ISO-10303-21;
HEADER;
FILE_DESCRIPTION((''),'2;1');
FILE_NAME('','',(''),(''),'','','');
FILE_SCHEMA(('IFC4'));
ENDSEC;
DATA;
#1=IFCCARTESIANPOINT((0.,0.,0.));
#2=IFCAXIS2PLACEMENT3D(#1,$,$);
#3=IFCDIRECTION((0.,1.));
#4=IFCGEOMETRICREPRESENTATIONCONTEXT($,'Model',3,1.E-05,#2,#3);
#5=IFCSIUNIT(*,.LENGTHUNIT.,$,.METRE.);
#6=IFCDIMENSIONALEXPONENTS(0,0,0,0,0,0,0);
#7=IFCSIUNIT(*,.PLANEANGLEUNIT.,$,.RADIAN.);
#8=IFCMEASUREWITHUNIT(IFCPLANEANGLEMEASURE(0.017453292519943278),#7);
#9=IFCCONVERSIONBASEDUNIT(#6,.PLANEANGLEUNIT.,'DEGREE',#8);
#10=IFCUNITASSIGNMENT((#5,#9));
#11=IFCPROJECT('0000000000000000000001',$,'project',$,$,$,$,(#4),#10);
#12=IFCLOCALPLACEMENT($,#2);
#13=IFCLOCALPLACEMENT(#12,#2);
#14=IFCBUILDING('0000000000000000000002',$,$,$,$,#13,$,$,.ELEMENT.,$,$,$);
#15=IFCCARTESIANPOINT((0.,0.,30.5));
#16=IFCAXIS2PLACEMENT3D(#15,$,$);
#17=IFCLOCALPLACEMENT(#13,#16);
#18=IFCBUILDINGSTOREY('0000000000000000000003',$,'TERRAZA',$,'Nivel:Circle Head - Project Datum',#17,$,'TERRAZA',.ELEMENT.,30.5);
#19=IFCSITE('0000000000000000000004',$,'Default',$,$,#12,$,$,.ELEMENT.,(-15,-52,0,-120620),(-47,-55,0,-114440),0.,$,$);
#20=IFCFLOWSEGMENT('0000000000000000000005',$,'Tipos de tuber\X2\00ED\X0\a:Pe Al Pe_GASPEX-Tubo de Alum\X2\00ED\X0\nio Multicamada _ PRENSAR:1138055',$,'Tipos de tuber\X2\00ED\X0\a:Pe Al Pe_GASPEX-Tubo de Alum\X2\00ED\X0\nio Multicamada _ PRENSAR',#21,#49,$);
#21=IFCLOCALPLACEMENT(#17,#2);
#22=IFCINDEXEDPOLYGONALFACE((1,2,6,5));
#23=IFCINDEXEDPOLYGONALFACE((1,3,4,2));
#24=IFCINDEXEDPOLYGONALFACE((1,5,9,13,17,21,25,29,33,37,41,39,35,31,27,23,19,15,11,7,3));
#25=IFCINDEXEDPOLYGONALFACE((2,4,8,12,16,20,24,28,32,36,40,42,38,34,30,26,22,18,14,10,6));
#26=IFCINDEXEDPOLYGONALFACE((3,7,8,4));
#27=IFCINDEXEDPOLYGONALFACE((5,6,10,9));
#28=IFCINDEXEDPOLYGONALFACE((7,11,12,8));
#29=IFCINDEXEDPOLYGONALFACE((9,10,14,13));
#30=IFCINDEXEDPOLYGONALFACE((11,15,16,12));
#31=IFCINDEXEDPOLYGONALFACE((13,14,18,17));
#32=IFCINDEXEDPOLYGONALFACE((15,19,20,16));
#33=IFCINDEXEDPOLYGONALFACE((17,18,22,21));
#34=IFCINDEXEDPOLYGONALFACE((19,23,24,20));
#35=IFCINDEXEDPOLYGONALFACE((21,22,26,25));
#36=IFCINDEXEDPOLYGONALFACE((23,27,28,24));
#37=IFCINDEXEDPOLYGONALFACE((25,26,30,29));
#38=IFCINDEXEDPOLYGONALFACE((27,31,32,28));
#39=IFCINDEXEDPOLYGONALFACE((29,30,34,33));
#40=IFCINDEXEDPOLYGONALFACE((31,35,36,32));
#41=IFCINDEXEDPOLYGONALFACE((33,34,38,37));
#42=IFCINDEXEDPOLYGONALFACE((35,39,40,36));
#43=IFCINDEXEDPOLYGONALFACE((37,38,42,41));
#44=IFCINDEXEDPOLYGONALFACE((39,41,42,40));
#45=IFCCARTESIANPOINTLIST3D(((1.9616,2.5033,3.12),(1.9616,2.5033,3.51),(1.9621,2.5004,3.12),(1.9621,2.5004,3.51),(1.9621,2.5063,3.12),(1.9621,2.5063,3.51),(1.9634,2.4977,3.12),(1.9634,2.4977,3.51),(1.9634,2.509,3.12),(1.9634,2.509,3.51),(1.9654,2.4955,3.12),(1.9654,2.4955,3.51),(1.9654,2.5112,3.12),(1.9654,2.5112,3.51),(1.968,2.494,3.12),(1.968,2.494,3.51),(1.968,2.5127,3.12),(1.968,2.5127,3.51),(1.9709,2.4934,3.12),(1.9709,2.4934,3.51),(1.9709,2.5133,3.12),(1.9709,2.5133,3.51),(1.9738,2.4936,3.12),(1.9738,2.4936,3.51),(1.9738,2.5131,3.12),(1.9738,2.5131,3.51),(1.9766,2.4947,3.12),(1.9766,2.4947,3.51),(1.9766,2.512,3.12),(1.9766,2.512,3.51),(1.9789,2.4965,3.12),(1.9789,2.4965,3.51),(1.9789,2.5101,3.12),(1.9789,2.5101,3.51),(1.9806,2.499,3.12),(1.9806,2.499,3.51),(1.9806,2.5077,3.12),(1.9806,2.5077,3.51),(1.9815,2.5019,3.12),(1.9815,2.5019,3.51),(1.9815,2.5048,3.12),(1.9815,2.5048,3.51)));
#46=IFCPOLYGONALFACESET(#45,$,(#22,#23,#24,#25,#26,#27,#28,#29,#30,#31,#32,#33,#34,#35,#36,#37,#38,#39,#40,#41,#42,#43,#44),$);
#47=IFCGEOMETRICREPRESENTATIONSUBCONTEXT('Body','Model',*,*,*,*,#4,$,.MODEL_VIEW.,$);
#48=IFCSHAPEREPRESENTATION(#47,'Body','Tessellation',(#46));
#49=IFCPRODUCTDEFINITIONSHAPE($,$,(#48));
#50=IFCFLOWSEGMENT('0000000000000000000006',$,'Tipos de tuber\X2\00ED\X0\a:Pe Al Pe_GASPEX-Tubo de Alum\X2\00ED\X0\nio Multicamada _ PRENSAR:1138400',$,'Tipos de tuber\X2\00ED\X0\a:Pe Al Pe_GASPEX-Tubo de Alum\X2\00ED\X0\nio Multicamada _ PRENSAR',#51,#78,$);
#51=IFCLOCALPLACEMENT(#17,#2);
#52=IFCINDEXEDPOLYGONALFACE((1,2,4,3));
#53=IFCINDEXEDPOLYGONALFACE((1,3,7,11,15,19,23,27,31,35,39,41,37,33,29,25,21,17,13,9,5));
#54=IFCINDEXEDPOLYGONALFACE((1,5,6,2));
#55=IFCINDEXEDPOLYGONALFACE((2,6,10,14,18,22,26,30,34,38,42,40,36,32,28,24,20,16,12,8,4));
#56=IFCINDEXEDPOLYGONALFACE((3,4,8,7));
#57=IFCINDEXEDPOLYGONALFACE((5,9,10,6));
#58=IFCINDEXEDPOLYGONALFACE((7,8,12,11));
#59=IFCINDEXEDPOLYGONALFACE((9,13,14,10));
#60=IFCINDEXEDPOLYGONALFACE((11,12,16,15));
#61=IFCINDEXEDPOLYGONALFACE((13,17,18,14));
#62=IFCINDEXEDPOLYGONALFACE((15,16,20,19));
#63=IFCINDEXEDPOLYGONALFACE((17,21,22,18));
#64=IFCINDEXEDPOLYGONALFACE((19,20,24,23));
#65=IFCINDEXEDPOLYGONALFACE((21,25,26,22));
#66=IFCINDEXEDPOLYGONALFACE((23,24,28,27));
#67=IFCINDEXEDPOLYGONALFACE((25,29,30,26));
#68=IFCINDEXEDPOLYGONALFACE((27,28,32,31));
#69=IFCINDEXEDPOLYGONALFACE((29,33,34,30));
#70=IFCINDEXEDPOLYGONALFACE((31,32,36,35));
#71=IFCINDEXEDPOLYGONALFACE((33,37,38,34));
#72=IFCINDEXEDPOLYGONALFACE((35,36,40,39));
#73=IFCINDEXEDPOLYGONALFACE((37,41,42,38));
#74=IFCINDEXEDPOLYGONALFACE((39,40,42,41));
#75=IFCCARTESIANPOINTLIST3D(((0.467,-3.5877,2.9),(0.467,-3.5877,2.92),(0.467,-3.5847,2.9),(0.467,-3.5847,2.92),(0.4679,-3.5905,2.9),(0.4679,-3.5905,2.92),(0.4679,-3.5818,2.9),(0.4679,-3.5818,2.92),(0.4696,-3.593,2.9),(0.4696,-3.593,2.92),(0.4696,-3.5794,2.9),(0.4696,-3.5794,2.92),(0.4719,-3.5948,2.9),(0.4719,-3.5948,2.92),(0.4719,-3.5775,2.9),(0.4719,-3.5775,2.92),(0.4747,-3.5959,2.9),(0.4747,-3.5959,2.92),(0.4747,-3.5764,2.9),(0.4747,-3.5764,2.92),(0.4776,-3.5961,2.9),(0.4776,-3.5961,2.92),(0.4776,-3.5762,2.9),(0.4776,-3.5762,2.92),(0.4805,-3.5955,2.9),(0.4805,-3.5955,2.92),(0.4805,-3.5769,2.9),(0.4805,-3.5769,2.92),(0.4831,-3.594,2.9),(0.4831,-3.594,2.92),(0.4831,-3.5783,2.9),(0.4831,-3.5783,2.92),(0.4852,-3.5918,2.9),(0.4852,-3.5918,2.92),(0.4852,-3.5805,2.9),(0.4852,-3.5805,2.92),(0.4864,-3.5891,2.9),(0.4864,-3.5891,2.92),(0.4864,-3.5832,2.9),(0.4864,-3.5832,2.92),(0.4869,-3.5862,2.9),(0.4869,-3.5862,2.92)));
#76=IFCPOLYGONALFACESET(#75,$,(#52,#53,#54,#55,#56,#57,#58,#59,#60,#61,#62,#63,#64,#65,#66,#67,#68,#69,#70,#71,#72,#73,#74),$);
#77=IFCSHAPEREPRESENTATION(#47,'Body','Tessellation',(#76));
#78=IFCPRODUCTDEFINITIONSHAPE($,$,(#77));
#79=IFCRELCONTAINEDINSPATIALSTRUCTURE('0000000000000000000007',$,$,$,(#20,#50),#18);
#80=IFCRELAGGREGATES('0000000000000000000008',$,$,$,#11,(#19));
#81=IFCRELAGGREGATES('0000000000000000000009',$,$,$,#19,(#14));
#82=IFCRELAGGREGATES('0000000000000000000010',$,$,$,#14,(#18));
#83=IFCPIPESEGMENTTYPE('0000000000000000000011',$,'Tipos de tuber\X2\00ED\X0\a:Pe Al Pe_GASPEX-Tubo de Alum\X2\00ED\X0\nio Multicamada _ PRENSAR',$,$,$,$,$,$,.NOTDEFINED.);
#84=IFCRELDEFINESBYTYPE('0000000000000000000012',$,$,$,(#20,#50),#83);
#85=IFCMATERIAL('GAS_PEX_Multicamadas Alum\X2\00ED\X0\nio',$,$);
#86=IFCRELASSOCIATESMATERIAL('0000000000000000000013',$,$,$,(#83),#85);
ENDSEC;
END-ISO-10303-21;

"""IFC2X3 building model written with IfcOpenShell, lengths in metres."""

from ifc_helpers import new_model, entity, si_unit, converted_unit, direction, frame, origin, origin_2d_with_axis, place, context, subcontext, project, spatial, circle, extrude, material, type_object, element, save


model = new_model("IFC2X3")

# Units and contexts
model_context = context("Model", 3, precision=1e-05, world=origin(), true_north=direction((0.0, 1.0)))
body_context = subcontext(model_context, "Body", "Model", "MODEL_VIEW")
ifc_project = project(units=[si_unit("LENGTHUNIT", "METRE"), converted_unit("PLANEANGLEUNIT", "DEGREE", entity("IfcPlaneAngleMeasure", 0.017453292519943278), si_unit("PLANEANGLEUNIT", "RADIAN"), dimensions=[0, 0, 0, 0, 0, 0, 0])], contexts=[model_context])

# Site, building, storey
site_placement = place(None, origin())
site = spatial("IfcSite", under=ifc_project, at=site_placement, Name="Default", CompositionType="ELEMENT", RefLatitude=(-15, -52, 0, -120620), RefLongitude=(-47, -55, 0, -114440), RefElevation=0.0)
building_placement = place(site_placement, origin())
building = spatial("IfcBuilding", under=site, at=building_placement, CompositionType="ELEMENT")
storey_placement = place(building_placement, frame((0.0, 0.0, 30.5)))
storey = spatial("IfcBuildingStorey", under=building, at=storey_placement, Name="TERRAZA", ObjectType="Nivel:Circle Head - Project Datum", LongName="TERRAZA", CompositionType="ELEMENT", Elevation=30.5)

# Flow segments
ifc_material = material(Name="GAS_PEX_Multicamadas Alumínio")
pipe_segment_type = type_object("IfcPipeSegmentType", Name="Tipos de tubería:Pe Al Pe_GASPEX-Tubo de Alumínio Multicamada _ PRENSAR", PredefinedType="NOTDEFINED", material=ifc_material)
flow_segment_1_placement = place(storey_placement, origin())
element("IfcFlowSegment", 1, at=flow_segment_1_placement, inside=storey, type_object=pipe_segment_type, Name="Tipos de tubería:Pe Al Pe_GASPEX-Tubo de Alumínio Multicamada _ PRENSAR:1138055", ObjectType="Tipos de tubería:Pe Al Pe_GASPEX-Tubo de Alumínio Multicamada _ PRENSAR", context=body_context, shape_type="SweptSolid", body=[
    extrude(circle(Radius=0.01, at=origin_2d_with_axis()), frame((1.9716, 2.5033, 3.12), z_axis=(0.0, 0.0, 1.0), x_axis=(-1.0, 0.0, 0.0)), (0.0, 0.0, 1.0), 0.39),
])
flow_segment_2_placement = place(storey_placement, origin())
element("IfcFlowSegment", 2, at=flow_segment_2_placement, inside=storey, type_object=pipe_segment_type, Name="Tipos de tubería:Pe Al Pe_GASPEX-Tubo de Alumínio Multicamada _ PRENSAR:1138400", ObjectType="Tipos de tubería:Pe Al Pe_GASPEX-Tubo de Alumínio Multicamada _ PRENSAR", context=body_context, shape_type="SweptSolid", body=[
    extrude(circle(Radius=0.01, at=origin_2d_with_axis()), frame((0.4769, -3.5862, 2.9)), (0.0, 0.0, 1.0), 0.02),
])

save(model, "model.ifc")
